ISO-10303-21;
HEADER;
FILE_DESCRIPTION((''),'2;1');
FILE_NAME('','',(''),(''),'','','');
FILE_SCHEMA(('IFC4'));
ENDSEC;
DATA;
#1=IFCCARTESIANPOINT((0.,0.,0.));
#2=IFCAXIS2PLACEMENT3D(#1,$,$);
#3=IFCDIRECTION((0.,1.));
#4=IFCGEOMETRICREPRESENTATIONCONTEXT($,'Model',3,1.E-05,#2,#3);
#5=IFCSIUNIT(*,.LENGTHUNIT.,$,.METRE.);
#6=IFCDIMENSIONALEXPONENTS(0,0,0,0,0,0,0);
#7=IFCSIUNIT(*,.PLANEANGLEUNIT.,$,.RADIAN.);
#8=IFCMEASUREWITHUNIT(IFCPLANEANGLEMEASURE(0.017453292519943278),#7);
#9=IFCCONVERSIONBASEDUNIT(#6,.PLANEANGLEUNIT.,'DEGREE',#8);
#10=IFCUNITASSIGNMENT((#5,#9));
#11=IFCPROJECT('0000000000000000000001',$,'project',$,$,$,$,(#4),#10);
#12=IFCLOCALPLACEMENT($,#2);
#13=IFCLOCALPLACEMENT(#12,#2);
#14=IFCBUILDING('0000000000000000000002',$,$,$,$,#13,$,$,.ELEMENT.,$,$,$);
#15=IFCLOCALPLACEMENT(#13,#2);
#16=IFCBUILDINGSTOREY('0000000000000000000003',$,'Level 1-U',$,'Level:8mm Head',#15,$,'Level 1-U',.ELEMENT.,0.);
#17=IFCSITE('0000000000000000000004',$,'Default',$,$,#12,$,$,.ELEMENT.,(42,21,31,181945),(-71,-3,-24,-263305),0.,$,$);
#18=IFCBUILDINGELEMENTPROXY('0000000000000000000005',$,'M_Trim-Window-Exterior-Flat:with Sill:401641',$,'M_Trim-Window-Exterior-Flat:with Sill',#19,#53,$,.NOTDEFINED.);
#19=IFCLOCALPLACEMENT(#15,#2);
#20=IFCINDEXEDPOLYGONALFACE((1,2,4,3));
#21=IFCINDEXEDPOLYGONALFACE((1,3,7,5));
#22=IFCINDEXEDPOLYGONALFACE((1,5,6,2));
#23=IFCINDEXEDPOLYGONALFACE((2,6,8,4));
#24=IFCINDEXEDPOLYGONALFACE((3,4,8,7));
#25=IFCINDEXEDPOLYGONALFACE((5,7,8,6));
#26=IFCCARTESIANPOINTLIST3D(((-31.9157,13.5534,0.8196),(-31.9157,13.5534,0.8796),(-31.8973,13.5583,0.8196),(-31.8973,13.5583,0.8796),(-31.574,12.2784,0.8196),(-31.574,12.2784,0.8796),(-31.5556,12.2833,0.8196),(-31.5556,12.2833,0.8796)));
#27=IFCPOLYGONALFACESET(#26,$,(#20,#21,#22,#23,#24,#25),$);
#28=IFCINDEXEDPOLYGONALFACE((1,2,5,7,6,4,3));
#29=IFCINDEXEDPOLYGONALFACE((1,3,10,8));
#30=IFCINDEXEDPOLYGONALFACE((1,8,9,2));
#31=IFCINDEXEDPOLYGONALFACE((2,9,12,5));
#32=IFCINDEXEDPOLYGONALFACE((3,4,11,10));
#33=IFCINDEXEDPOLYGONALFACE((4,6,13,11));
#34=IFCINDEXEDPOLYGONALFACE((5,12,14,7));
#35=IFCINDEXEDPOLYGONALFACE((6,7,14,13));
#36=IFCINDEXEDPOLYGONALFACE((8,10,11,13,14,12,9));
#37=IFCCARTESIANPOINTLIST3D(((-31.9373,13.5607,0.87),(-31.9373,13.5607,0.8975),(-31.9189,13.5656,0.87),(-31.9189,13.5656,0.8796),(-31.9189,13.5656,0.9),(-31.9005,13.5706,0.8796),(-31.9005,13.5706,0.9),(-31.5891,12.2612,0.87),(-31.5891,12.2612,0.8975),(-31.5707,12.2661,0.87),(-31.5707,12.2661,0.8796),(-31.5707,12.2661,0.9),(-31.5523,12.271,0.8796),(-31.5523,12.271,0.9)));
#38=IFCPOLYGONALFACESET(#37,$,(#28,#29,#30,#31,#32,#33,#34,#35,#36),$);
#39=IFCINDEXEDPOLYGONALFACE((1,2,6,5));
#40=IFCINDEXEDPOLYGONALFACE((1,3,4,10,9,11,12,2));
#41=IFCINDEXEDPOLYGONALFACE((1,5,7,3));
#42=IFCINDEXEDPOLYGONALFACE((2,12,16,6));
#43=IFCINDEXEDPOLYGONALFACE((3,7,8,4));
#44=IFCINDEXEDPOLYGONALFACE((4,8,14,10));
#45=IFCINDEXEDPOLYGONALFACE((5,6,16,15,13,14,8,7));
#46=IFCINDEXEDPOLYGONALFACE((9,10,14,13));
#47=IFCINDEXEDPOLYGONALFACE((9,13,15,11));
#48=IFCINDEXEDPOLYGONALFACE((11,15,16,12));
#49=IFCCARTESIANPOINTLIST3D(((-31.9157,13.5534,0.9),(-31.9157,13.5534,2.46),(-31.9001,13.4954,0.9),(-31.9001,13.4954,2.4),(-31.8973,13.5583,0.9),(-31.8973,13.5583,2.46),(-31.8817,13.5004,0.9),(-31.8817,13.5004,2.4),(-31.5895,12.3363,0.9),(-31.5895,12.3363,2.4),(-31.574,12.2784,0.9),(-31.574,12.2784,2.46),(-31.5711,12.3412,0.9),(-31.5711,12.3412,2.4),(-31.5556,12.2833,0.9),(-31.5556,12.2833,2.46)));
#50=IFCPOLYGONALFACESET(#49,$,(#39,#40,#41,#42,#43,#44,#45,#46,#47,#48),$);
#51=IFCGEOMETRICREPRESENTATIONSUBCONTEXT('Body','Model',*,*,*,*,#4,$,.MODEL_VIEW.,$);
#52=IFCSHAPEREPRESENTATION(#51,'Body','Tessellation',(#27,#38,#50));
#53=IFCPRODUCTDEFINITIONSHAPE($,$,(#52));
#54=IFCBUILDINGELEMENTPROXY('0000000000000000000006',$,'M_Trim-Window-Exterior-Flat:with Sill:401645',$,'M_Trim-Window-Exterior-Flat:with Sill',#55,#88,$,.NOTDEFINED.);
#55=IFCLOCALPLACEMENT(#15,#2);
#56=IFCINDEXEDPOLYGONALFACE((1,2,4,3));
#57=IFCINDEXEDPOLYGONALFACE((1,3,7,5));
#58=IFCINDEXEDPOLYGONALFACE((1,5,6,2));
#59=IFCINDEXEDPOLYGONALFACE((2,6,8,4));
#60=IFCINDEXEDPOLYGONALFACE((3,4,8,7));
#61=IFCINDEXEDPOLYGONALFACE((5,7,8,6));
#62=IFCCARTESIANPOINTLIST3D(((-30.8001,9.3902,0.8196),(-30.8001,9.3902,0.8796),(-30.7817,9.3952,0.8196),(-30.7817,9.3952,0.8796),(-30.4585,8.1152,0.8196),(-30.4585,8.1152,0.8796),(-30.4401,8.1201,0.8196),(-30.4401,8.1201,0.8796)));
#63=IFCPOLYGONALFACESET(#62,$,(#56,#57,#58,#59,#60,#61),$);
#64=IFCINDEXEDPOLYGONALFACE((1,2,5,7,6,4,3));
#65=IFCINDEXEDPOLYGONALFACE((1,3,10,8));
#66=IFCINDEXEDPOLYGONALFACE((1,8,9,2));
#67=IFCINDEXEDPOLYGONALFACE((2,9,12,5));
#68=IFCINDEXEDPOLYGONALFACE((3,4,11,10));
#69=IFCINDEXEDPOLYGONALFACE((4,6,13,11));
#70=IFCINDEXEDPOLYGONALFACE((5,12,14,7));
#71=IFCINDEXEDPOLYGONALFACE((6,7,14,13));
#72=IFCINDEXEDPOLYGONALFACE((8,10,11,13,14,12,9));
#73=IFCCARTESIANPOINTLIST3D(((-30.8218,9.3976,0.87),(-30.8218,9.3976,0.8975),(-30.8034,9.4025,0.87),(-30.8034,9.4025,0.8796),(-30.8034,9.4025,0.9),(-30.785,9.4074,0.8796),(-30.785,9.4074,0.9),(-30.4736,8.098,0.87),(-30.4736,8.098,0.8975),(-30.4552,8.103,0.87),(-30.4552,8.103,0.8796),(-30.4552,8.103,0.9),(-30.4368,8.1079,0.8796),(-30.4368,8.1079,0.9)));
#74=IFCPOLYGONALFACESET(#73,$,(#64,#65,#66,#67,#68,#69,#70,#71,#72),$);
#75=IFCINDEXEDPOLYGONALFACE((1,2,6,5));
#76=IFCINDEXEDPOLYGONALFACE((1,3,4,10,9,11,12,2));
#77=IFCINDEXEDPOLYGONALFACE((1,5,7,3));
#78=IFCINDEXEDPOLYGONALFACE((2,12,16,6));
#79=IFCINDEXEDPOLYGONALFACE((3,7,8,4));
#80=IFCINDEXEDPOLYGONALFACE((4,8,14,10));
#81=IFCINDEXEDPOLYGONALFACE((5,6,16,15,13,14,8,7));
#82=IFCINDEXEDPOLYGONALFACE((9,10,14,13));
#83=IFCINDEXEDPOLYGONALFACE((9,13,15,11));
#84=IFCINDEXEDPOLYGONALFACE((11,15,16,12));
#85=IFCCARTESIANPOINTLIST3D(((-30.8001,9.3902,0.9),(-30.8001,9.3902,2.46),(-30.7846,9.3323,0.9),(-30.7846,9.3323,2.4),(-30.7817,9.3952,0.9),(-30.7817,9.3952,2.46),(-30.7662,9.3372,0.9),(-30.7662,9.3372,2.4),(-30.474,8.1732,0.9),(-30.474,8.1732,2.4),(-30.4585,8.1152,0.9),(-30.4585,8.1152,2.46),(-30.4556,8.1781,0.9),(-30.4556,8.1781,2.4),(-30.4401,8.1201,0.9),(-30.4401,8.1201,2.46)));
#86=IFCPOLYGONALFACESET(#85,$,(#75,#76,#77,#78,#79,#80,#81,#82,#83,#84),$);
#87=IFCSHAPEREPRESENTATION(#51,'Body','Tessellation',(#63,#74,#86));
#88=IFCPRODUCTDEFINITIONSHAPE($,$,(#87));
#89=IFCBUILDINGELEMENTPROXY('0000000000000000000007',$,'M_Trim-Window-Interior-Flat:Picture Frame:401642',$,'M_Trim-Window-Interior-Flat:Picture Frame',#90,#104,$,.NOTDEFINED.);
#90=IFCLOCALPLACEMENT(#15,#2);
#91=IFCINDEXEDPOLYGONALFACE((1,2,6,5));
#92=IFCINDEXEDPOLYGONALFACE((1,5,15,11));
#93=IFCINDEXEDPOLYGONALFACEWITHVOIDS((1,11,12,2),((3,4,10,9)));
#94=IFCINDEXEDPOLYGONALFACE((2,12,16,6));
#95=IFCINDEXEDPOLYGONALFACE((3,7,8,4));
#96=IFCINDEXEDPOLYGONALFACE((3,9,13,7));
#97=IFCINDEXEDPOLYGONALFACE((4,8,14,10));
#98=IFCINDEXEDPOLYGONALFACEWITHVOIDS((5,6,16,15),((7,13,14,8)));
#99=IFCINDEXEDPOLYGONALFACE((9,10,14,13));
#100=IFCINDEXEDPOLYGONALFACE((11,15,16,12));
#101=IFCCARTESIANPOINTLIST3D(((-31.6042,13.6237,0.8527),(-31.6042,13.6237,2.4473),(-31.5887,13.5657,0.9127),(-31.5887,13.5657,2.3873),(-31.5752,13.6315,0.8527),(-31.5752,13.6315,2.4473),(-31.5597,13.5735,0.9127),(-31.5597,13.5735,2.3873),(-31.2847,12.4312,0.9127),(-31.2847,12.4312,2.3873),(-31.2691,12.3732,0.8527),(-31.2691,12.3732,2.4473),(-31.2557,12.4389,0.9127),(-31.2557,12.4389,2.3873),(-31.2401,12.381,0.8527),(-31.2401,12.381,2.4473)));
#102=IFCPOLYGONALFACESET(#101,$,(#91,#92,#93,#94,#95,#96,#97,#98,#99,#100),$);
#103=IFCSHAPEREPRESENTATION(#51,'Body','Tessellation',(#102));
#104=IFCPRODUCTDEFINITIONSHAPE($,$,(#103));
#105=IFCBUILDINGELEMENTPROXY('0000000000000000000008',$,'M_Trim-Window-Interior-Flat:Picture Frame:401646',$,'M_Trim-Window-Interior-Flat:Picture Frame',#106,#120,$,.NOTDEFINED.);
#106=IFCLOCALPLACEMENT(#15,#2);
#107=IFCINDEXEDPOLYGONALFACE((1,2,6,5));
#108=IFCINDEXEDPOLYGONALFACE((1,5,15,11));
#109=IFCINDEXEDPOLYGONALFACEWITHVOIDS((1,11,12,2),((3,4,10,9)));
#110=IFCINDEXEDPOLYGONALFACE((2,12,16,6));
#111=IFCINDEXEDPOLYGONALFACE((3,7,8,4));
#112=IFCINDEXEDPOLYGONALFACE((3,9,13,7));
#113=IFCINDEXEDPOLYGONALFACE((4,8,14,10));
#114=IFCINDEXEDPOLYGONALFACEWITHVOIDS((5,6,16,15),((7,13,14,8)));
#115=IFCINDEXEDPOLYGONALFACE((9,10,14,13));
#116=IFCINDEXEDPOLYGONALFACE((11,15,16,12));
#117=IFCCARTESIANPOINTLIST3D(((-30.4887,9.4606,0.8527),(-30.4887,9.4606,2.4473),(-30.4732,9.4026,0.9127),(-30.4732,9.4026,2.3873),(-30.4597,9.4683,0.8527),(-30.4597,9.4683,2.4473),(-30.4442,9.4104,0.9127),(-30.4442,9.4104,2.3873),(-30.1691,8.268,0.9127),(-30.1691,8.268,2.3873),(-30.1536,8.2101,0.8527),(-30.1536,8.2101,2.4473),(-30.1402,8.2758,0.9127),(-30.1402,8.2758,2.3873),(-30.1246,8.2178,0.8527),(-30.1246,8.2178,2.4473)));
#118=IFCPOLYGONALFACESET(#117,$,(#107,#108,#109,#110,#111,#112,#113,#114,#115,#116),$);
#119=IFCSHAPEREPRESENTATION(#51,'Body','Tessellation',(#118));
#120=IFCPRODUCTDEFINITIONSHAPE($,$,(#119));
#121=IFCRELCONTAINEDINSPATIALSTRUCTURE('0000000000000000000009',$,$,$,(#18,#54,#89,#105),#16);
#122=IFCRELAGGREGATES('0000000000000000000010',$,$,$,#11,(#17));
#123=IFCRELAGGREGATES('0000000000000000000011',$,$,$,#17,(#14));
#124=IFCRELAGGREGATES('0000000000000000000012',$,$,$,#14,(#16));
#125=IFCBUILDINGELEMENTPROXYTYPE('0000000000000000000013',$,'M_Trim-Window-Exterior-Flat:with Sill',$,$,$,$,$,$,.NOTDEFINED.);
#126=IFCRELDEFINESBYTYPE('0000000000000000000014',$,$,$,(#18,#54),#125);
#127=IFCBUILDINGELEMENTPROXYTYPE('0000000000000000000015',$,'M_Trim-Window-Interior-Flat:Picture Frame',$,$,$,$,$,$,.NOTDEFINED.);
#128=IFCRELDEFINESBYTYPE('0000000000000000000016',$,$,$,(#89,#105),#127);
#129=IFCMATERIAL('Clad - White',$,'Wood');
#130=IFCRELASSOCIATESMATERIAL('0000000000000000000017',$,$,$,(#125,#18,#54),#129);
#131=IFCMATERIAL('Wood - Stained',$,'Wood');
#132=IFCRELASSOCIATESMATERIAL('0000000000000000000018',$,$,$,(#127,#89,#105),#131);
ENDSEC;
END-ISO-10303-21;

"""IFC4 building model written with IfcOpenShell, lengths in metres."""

from ifc_helpers import new_model, entity, si_unit, converted_unit, direction, frame, frame_2d, origin, place, context, subcontext, project, spatial, polyline, rectangle, outline, extrude, source, transform, mapped, material, type_object, type_shapes, element, save


model = new_model("IFC4")

# Units and contexts
model_context = context("Model", 3, precision=1e-05, world=origin(), true_north=direction((0.0, 1.0)))
body_context = subcontext(model_context, "Body", "Model", "MODEL_VIEW")
ifc_project = project(units=[si_unit("LENGTHUNIT", "METRE"), converted_unit("PLANEANGLEUNIT", "DEGREE", entity("IfcPlaneAngleMeasure", 0.017453292519943278), si_unit("PLANEANGLEUNIT", "RADIAN"), dimensions=[0, 0, 0, 0, 0, 0, 0])], contexts=[model_context])

# Site, building, storey
site_placement = place(None, origin())
site = spatial("IfcSite", under=ifc_project, at=site_placement, Name="Default", CompositionType="ELEMENT", RefLatitude=(42, 21, 31, 181945), RefLongitude=(-71, -3, -24, -263305), RefElevation=0.0)
building_placement = place(site_placement, origin())
building = spatial("IfcBuilding", under=site, at=building_placement, CompositionType="ELEMENT")
storey_placement = place(building_placement, origin())
storey = spatial("IfcBuildingStorey", under=building, at=storey_placement, Name="Level 1-U", ObjectType="Level:8mm Head", LongName="Level 1-U", CompositionType="ELEMENT", Elevation=0.0)

# Building element proxies
ifc_material_1 = material(Name="Clad - White", Category="Wood")
ifc_material_2 = material(Name="Wood - Stained", Category="Wood")
building_element_proxy_type_1 = type_object("IfcBuildingElementProxyType", Name="M_Trim-Window-Exterior-Flat:with Sill", PredefinedType="NOTDEFINED", material=ifc_material_1)
shared_shape_1 = source(origin(), body_context, "Body", "SweptSolid", [
    extrude(rectangle(XDim=1.32, YDim=0.06, at=frame_2d((0.0, 0.0), x_axis=(1.0, 0.0))), frame((0.0, -1.5504, 0.0), z_axis=(0.0, 0.0, 1.0), x_axis=(-1.0, 0.0, 0.0)), (0.0, 0.0, 1.0), 0.019),
    extrude(outline(polyline([(-0.019, -0.0152), (0.0, -0.0152), (0.0, -0.0057), (0.019, -0.0057), (0.019, 0.0148), (0.0, 0.0148), (-0.019, 0.0123), (-0.019, -0.0152)])), frame((-0.6727, -1.5148, 0.019), z_axis=(1.0, 0.0, 0.0), x_axis=(0.0, 0.0, -1.0)), (0.0, 0.0, 1.0), 1.3454),
    extrude(outline(polyline([(-0.795, -0.66), (0.765, -0.66), (0.765, -0.6), (-0.735, -0.6), (-0.735, 0.6), (0.765, 0.6), (0.765, 0.66), (-0.795, 0.66), (-0.795, -0.66)])), frame((0.0, -0.735, 0.0), z_axis=(0.0, 0.0, 1.0), x_axis=(0.0, -1.0, 0.0)), (0.0, 0.0, 1.0), 0.019),
])
type_shapes(building_element_proxy_type_1, [shared_shape_1])
for number, where, z_axis, x_axis, name in (
    (1, (-31.7264, 12.9208, 2.4), (-0.965926, -0.258819, 0.0), (0.258819, -0.965926, 0.0), "M_Trim-Window-Exterior-Flat:with Sill:401641"),
    (2, (-30.6109, 8.7577, 2.4), (-0.965926, -0.258819, 0.0), (0.258819, -0.965926, 0.0), "M_Trim-Window-Exterior-Flat:with Sill:401645"),
):
    element("IfcBuildingElementProxy", number, at=place(storey_placement, frame(where, z_axis=z_axis, x_axis=x_axis)), inside=storey, type_object=building_element_proxy_type_1, material=ifc_material_1, Name=name, ObjectType="M_Trim-Window-Exterior-Flat:with Sill", PredefinedType="NOTDEFINED", context=body_context, shape_type="MappedRepresentation", body=[
        mapped(shared_shape_1, transform((0.0, 0.0, 0.0), scale=1.0)),
    ])
building_element_proxy_type_2 = type_object("IfcBuildingElementProxyType", Name="M_Trim-Window-Interior-Flat:Picture Frame", PredefinedType="NOTDEFINED", material=ifc_material_2)
shared_shape_2 = source(origin(), body_context, "Body", "SweptSolid", [
    extrude(outline(polyline([(-0.6473, -0.7973), (0.6473, -0.7973), (0.6473, 0.7973), (-0.6473, 0.7973), (-0.6473, -0.7973)]), holes=[polyline([(-0.5873, -0.7373), (-0.5873, 0.7373), (0.5873, 0.7373), (0.5873, -0.7373), (-0.5873, -0.7373)])]), frame((0.0, -0.75, 0.0), z_axis=(0.0, 0.0, 1.0), x_axis=(-1.0, 0.0, 0.0)), (0.0, 0.0, 1.0), 0.03),
])
type_shapes(building_element_proxy_type_2, [shared_shape_2])
for number, where, z_axis, x_axis, name in (
    (3, (-31.4367, 12.9984, 2.4), (0.965926, 0.258819, 0.0), (-0.258819, 0.965926, 0.0), "M_Trim-Window-Interior-Flat:Picture Frame:401642"),
    (4, (-30.3211, 8.8353, 2.4), (0.965926, 0.258819, 0.0), (-0.258819, 0.965926, 0.0), "M_Trim-Window-Interior-Flat:Picture Frame:401646"),
):
    element("IfcBuildingElementProxy", number, at=place(storey_placement, frame(where, z_axis=z_axis, x_axis=x_axis)), inside=storey, type_object=building_element_proxy_type_2, material=ifc_material_2, Name=name, ObjectType="M_Trim-Window-Interior-Flat:Picture Frame", PredefinedType="NOTDEFINED", context=body_context, shape_type="MappedRepresentation", body=[
        mapped(shared_shape_2, transform((0.0, 0.0, 0.0), scale=1.0)),
    ])

save(model, "model.ifc")
